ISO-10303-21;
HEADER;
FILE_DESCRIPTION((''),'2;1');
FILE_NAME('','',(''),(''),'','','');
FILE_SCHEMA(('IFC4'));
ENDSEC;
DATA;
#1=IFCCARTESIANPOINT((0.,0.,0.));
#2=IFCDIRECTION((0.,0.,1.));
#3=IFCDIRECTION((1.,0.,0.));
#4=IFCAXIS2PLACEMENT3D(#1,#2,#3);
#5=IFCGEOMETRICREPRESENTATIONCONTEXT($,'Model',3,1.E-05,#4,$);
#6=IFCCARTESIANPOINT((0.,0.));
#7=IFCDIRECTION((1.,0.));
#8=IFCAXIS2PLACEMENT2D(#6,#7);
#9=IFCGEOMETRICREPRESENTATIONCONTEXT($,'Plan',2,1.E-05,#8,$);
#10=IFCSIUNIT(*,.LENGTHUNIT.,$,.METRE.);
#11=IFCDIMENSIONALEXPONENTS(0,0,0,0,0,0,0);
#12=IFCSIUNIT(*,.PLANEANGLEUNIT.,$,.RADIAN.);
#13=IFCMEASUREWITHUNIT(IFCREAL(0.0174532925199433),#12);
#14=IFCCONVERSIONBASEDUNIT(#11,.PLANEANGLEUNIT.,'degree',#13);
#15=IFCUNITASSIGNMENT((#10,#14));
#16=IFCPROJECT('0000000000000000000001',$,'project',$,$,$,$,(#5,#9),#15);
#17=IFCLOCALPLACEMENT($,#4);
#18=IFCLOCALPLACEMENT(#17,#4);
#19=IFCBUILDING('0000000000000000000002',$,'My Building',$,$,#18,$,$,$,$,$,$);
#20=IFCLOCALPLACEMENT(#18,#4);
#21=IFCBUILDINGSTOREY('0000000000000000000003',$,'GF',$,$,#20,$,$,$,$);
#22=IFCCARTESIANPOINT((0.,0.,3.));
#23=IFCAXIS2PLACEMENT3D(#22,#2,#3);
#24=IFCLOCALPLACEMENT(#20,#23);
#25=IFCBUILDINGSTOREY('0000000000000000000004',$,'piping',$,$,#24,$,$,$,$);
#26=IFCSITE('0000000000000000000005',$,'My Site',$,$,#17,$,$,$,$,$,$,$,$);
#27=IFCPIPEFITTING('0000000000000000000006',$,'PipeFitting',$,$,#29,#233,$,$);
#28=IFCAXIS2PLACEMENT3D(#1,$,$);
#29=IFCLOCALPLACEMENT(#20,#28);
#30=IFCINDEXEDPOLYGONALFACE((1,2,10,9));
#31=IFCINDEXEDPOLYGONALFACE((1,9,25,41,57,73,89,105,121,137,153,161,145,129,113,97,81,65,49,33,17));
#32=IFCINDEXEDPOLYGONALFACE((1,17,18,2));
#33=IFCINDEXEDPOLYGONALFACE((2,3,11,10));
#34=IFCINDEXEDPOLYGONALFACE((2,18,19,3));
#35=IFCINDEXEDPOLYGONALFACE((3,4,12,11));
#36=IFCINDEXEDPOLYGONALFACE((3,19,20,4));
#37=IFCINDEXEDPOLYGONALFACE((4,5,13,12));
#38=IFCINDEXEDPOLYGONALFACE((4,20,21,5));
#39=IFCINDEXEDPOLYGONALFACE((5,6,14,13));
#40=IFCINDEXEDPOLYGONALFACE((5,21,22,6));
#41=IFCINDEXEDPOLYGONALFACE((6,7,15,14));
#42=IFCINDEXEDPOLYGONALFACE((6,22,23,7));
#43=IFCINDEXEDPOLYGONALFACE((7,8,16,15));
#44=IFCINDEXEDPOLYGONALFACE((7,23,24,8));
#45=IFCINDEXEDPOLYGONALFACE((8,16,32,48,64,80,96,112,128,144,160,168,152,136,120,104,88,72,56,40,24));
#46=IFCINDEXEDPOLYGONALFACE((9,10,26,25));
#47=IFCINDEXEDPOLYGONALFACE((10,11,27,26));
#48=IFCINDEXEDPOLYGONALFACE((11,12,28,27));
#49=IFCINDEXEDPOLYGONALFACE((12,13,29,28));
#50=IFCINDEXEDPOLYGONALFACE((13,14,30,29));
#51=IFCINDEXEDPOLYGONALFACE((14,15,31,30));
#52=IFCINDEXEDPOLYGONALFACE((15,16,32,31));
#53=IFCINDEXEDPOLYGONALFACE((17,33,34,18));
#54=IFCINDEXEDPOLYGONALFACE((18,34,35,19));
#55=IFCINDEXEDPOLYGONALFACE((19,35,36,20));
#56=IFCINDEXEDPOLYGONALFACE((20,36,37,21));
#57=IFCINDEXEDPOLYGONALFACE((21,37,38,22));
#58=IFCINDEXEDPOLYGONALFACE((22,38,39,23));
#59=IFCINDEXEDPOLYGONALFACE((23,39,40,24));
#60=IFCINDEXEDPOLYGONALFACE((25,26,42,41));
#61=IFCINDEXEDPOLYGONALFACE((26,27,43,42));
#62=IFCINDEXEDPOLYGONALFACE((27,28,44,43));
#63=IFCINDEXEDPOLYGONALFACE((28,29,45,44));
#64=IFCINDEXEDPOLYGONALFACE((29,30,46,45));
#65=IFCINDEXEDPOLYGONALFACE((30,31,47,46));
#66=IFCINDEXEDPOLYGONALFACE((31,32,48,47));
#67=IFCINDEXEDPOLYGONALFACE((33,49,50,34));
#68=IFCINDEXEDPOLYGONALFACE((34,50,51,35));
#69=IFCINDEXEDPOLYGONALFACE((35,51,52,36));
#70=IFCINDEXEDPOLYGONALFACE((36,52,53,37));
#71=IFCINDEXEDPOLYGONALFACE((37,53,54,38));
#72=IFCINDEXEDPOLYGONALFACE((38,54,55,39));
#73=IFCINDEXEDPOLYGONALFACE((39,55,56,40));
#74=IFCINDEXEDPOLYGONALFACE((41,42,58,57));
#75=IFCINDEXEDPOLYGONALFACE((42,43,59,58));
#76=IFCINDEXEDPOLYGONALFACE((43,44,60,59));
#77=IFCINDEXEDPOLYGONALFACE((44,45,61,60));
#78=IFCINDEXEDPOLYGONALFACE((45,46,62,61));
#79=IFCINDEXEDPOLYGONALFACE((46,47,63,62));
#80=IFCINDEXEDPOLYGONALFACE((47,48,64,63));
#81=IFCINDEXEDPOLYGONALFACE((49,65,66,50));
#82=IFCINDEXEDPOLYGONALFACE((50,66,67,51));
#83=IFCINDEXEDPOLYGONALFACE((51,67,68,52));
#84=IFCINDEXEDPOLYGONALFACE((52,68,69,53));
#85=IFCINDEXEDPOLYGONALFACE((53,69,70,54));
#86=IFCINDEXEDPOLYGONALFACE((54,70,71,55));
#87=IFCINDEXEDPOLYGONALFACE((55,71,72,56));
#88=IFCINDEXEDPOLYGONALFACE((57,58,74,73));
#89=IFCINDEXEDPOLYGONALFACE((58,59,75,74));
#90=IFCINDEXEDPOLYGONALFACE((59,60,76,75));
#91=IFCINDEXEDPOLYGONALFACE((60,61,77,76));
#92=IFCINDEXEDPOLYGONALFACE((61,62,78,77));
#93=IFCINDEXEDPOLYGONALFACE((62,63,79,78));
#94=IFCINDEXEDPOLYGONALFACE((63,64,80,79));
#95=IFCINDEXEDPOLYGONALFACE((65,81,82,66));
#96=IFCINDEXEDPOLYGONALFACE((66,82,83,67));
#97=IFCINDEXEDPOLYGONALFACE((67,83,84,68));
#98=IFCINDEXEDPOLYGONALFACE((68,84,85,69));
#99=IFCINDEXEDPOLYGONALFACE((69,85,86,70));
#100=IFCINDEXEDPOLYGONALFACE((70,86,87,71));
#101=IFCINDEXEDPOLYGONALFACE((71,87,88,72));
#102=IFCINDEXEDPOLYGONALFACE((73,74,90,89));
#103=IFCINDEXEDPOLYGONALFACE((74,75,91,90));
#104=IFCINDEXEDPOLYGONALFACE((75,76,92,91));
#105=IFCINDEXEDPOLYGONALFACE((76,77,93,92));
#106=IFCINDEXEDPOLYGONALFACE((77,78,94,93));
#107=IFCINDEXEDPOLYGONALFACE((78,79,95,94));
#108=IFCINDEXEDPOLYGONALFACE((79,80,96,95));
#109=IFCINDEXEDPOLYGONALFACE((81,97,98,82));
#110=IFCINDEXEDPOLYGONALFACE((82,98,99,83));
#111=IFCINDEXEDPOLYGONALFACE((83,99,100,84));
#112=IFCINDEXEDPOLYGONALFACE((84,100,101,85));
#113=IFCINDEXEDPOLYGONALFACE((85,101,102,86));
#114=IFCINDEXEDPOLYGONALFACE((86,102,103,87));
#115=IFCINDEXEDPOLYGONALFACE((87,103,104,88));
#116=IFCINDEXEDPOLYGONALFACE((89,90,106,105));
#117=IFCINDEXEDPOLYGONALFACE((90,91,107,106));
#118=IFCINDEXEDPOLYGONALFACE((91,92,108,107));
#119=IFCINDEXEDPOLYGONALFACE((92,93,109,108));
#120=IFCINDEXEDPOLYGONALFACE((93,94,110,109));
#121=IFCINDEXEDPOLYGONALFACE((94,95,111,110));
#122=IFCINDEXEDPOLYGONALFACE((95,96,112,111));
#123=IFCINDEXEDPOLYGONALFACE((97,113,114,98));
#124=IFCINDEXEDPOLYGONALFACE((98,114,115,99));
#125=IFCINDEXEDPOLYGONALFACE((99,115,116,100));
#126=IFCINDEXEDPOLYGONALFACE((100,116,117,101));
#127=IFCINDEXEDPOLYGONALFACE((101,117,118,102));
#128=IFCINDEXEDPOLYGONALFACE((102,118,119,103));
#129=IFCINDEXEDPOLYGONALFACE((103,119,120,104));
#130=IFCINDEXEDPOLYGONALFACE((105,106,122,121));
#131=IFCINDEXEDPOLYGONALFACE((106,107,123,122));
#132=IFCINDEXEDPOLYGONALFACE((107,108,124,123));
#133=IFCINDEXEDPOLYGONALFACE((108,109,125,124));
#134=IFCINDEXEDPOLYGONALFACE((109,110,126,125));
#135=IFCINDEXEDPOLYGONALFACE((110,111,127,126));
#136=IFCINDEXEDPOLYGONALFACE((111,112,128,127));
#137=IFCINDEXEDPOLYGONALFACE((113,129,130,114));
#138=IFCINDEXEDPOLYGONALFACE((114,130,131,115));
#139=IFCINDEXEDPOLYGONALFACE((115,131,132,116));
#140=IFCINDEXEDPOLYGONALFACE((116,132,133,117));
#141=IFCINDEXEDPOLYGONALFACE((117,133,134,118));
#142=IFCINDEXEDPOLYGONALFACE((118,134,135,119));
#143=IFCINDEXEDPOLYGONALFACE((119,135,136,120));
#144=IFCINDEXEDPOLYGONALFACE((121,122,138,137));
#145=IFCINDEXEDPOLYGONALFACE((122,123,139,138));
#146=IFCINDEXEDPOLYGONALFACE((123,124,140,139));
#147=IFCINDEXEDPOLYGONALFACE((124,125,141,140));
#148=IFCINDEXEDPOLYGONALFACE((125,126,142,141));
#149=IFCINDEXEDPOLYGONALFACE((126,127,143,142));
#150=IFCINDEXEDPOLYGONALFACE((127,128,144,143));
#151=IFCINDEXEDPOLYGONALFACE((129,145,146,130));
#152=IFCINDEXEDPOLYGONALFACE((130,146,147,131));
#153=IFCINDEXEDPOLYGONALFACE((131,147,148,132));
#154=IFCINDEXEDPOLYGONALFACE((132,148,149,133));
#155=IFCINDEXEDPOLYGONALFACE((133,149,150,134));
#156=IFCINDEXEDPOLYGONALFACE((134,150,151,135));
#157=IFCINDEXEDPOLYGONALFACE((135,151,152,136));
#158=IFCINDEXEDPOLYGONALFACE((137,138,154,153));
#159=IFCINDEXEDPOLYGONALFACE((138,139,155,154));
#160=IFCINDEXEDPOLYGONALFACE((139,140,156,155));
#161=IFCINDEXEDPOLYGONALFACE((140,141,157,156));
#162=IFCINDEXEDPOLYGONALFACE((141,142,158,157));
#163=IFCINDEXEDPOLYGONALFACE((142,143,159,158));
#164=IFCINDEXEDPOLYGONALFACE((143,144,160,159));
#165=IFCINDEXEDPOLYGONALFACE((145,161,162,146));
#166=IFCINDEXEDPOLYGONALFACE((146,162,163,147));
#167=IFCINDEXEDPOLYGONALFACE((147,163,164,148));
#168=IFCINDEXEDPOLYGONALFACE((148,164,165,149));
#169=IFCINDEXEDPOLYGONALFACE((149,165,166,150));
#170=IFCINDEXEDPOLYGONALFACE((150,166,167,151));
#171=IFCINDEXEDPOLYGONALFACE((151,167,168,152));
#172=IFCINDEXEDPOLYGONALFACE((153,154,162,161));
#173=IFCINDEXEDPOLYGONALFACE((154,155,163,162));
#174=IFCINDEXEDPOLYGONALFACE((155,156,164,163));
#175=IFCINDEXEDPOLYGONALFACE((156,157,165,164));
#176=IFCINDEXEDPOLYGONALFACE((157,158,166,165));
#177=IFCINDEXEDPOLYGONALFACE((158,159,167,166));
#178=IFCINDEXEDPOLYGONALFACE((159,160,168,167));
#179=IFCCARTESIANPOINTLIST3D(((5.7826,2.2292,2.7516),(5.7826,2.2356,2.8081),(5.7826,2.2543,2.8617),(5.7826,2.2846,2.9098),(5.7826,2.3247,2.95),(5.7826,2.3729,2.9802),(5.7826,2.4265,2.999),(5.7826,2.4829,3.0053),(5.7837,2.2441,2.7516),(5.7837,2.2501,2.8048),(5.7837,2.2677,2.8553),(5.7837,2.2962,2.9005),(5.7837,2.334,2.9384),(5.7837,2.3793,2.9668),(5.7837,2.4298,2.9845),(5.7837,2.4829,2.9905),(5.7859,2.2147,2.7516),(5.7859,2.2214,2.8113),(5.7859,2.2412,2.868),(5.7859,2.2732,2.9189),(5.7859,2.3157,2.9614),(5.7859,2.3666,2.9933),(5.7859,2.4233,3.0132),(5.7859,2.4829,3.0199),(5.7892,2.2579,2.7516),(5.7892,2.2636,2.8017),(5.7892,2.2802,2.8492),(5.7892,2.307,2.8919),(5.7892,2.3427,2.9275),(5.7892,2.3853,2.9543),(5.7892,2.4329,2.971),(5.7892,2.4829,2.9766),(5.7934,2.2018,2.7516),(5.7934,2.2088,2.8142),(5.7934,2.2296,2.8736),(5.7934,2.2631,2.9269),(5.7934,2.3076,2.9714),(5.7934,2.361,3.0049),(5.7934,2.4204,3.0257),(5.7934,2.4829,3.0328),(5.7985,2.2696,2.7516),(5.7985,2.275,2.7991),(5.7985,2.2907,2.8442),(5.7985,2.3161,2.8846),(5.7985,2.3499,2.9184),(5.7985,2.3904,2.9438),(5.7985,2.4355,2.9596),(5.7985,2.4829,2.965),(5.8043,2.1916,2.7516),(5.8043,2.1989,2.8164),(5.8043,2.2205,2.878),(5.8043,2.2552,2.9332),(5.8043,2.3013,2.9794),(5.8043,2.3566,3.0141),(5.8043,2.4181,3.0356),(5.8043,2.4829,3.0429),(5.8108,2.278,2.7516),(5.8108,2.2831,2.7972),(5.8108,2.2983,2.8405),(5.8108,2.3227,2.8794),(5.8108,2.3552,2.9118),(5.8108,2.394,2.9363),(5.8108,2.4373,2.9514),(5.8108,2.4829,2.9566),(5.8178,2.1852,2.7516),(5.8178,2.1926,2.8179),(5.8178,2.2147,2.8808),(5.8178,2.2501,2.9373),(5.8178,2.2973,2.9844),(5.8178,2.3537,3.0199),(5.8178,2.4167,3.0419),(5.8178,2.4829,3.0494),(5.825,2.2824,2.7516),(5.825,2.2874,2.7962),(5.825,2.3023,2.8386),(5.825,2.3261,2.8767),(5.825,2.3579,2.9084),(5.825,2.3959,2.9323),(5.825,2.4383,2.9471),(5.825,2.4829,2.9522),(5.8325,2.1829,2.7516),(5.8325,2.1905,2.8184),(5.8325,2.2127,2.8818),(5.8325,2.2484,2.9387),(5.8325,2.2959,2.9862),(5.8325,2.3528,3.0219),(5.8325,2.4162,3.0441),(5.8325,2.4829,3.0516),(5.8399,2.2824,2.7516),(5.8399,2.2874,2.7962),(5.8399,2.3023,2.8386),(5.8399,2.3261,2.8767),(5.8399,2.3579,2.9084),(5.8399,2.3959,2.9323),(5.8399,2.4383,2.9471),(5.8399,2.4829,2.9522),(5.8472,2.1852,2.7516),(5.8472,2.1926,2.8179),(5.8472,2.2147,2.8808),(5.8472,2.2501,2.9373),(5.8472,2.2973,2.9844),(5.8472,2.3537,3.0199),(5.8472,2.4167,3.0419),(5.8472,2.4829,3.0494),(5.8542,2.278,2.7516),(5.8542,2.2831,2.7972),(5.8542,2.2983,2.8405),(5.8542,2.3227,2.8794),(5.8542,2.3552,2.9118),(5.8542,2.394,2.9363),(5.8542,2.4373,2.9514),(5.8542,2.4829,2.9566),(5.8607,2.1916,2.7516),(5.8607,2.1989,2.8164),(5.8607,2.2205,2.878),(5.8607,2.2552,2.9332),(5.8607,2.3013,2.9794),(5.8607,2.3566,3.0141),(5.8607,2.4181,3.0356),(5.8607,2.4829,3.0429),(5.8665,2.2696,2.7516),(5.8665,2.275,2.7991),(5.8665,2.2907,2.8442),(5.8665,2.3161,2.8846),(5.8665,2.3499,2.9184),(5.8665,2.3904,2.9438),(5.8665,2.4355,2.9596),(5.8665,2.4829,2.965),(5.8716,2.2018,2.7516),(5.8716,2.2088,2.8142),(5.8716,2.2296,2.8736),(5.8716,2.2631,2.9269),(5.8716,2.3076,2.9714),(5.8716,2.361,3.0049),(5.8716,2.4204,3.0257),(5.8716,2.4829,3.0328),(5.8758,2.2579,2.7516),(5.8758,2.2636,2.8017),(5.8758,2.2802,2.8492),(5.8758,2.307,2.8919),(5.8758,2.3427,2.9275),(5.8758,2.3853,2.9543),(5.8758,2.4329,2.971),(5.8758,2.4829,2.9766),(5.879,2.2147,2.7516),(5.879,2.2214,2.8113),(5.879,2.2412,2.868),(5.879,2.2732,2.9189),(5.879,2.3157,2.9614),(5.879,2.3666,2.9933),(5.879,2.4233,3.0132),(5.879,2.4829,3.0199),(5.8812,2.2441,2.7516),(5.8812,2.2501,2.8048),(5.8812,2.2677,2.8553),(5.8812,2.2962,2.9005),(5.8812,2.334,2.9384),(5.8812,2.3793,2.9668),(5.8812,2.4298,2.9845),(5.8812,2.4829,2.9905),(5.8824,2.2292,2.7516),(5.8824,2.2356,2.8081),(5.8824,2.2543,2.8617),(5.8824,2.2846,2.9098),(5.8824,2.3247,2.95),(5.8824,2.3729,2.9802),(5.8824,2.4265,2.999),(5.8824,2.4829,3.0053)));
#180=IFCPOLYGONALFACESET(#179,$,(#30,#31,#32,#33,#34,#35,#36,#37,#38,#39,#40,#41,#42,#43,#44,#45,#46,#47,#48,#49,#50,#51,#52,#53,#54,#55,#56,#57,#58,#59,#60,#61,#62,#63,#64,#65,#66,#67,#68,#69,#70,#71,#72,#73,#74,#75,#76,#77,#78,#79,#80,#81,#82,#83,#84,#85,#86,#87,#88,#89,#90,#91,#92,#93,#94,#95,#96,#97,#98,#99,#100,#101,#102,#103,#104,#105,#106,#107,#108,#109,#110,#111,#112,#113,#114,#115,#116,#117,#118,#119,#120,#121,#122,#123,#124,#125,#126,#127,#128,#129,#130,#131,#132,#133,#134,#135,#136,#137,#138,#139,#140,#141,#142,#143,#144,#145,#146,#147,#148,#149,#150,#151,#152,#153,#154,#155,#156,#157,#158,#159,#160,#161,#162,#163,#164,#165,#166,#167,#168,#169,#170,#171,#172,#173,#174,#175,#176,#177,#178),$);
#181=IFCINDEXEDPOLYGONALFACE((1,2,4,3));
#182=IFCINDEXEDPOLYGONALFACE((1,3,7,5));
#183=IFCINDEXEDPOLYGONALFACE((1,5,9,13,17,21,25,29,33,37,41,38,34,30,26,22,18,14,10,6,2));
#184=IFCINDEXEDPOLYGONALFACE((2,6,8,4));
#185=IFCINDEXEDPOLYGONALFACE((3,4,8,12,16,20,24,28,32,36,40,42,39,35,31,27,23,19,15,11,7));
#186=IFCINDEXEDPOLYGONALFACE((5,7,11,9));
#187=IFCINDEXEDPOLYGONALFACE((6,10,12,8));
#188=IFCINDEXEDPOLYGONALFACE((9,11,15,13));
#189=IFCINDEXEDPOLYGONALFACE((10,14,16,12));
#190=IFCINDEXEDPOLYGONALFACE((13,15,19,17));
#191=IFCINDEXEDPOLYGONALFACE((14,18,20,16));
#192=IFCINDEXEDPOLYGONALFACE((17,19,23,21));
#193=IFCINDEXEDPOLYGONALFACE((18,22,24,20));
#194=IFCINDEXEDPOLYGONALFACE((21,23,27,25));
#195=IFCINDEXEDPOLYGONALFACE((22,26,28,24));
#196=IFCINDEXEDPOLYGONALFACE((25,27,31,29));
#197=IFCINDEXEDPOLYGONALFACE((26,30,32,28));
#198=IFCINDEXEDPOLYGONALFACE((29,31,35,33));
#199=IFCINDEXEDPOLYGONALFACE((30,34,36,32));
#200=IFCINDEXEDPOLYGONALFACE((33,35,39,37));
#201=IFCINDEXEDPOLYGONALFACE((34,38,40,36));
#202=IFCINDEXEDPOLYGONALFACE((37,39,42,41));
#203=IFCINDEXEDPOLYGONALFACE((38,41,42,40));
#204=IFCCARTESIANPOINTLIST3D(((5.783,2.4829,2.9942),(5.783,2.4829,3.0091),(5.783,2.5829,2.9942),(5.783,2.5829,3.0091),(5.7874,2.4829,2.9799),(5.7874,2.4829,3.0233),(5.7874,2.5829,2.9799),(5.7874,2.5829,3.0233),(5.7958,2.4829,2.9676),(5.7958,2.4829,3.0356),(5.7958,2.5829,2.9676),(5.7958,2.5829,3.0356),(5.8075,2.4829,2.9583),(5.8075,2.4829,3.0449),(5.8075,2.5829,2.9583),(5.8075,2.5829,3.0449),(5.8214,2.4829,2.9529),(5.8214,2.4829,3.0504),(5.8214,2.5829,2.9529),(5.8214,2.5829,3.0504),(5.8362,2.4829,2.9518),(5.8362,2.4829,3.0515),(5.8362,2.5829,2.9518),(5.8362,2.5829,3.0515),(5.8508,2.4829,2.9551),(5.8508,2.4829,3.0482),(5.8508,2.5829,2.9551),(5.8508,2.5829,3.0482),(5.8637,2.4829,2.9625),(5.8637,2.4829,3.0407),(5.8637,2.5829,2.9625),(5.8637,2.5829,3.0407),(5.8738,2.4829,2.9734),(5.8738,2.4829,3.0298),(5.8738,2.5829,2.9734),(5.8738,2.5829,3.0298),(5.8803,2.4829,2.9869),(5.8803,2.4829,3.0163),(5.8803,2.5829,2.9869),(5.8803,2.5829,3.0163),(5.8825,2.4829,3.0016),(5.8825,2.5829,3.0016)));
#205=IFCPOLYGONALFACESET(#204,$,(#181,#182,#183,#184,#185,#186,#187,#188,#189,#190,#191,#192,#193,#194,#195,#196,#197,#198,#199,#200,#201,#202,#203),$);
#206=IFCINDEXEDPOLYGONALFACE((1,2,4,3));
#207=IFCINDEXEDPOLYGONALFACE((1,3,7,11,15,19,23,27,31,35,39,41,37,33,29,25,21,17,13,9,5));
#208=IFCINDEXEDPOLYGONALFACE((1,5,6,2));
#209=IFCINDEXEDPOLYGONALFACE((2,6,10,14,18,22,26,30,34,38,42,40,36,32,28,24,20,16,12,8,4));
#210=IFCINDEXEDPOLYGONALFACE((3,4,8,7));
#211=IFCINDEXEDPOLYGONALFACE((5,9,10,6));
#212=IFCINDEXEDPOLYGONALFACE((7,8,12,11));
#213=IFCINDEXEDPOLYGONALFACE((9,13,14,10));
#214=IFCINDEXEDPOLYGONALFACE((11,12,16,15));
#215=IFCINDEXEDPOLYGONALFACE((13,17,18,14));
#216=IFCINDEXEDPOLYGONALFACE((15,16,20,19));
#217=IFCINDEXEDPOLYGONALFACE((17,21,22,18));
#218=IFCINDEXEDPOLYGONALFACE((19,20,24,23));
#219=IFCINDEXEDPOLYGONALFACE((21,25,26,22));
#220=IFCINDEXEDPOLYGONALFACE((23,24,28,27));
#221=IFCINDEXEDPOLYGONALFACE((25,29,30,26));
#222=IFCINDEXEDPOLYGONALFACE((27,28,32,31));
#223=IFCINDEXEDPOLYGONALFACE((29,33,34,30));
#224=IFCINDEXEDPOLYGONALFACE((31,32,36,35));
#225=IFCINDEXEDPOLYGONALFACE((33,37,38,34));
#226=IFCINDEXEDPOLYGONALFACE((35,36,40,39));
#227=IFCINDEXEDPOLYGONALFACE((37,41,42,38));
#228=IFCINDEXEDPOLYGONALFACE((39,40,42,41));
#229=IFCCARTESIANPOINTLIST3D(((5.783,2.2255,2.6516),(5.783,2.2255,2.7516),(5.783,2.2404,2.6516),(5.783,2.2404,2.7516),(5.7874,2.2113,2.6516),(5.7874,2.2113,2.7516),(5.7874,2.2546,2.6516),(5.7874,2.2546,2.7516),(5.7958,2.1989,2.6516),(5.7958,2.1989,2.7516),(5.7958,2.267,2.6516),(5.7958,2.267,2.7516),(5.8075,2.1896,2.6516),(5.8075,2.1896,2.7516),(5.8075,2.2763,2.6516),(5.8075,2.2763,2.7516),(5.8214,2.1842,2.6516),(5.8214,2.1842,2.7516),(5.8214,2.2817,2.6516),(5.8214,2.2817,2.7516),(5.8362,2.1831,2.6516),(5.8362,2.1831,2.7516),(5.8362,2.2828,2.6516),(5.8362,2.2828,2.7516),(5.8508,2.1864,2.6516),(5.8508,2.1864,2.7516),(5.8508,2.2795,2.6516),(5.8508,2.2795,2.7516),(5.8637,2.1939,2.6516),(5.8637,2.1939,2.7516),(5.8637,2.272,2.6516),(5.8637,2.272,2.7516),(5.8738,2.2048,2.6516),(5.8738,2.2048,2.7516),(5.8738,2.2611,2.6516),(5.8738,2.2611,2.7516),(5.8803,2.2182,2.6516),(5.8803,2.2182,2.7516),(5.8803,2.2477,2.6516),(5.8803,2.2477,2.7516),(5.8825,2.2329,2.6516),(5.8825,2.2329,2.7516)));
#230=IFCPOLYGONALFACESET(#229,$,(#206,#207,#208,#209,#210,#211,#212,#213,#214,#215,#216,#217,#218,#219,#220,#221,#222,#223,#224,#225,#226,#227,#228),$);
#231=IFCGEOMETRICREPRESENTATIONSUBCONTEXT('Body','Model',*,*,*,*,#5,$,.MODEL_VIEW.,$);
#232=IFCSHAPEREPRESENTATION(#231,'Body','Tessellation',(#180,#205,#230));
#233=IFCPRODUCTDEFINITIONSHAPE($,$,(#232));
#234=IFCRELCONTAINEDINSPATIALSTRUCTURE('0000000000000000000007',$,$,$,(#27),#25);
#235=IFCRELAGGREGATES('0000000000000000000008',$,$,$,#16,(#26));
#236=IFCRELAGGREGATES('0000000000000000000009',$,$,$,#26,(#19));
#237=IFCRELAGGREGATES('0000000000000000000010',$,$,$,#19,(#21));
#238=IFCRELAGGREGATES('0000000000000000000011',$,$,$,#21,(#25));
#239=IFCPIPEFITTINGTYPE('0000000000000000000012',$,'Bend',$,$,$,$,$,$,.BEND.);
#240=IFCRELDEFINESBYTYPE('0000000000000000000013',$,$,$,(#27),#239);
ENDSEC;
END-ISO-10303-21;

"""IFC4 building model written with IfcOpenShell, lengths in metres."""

from ifc_helpers import new_model, entity, si_unit, converted_unit, frame, origin_with_axes, origin_2d_with_axis, place, context, subcontext, project, spatial, circle, extrude, source, transform, mapped, type_object, type_shapes, element, save


model = new_model("IFC4")

# Units and contexts
model_context = context("Model", 3, precision=1e-05, world=origin_with_axes())
plan_context = context("Plan", 2, precision=1e-05, world=origin_2d_with_axis())
body_context = subcontext(model_context, "Body", "Model", "MODEL_VIEW")
ifc_project = project(units=[si_unit("LENGTHUNIT", "METRE"), converted_unit("PLANEANGLEUNIT", "degree", entity("IfcReal", 0.0174532925199433), si_unit("PLANEANGLEUNIT", "RADIAN"), dimensions=[0, 0, 0, 0, 0, 0, 0])], contexts=[model_context, plan_context])

# Site, building, storeys
site_placement = place(None, origin_with_axes())
site = spatial("IfcSite", under=ifc_project, at=site_placement, Name="My Site")
building_placement = place(site_placement, origin_with_axes())
building = spatial("IfcBuilding", under=site, at=building_placement, Name="My Building")
storey_1_placement = place(building_placement, origin_with_axes())
storey_1 = spatial("IfcBuildingStorey", under=building, at=storey_1_placement, Name="GF")
storey_2_placement = place(storey_1_placement, frame((0.0, 0.0, 3.0), z_axis=(0.0, 0.0, 1.0), x_axis=(1.0, 0.0, 0.0)))
storey_2 = spatial("IfcBuildingStorey", under=storey_1, at=storey_2_placement, Name="piping")

# Pipe fitting
pipe_fitting_type = type_object("IfcPipeFittingType", Name="Bend", PredefinedType="BEND")
shared_shape = source(origin_with_axes(), body_context, "Body", "SolidModel", [
    entity("IfcSweptDiskSolid", entity("IfcIndexedPolyCurve", entity("IfcCartesianPointList3D", [[0.0, 0.0, -0.1], [0.0, 0.0732, -0.2768], [0.0, 0.25, -0.35]]), [entity("IfcArcIndex", [1, 2, 3])]), 0.05),
    extrude(circle(Radius=0.05), origin_with_axes(), (0.0, 0.0, -1.0), 0.1),
    extrude(circle(Radius=0.05), frame((0.0, 0.25, -0.35), z_axis=(0.0, 1.0, 0.0), x_axis=(1.0, 0.0, 0.0)), (0.0, 0.0, 1.0), 0.1),
])
type_shapes(pipe_fitting_type, [shared_shape])
for number, where, z_axis, x_axis, name in (
    (1, (5.8325, 2.5829, 0.0016), (0.0, 1.0, 0.0), (1.0, 0.0, 0.0), "PipeFitting"),
):
    element("IfcPipeFitting", number, at=place(storey_2_placement, frame(where, z_axis=z_axis, x_axis=x_axis)), inside=storey_2, type_object=pipe_fitting_type, Name=name, context=body_context, shape_type="MappedRepresentation", body=[
        mapped(shared_shape, transform((0.0, 0.0, 0.0), x_axis=(1.0, 0.0, 0.0), y_axis=(0.0, 1.0, 0.0), z_axis=(0.0, 0.0, 1.0), scale=1.0)),
    ])

save(model, "model.ifc")
